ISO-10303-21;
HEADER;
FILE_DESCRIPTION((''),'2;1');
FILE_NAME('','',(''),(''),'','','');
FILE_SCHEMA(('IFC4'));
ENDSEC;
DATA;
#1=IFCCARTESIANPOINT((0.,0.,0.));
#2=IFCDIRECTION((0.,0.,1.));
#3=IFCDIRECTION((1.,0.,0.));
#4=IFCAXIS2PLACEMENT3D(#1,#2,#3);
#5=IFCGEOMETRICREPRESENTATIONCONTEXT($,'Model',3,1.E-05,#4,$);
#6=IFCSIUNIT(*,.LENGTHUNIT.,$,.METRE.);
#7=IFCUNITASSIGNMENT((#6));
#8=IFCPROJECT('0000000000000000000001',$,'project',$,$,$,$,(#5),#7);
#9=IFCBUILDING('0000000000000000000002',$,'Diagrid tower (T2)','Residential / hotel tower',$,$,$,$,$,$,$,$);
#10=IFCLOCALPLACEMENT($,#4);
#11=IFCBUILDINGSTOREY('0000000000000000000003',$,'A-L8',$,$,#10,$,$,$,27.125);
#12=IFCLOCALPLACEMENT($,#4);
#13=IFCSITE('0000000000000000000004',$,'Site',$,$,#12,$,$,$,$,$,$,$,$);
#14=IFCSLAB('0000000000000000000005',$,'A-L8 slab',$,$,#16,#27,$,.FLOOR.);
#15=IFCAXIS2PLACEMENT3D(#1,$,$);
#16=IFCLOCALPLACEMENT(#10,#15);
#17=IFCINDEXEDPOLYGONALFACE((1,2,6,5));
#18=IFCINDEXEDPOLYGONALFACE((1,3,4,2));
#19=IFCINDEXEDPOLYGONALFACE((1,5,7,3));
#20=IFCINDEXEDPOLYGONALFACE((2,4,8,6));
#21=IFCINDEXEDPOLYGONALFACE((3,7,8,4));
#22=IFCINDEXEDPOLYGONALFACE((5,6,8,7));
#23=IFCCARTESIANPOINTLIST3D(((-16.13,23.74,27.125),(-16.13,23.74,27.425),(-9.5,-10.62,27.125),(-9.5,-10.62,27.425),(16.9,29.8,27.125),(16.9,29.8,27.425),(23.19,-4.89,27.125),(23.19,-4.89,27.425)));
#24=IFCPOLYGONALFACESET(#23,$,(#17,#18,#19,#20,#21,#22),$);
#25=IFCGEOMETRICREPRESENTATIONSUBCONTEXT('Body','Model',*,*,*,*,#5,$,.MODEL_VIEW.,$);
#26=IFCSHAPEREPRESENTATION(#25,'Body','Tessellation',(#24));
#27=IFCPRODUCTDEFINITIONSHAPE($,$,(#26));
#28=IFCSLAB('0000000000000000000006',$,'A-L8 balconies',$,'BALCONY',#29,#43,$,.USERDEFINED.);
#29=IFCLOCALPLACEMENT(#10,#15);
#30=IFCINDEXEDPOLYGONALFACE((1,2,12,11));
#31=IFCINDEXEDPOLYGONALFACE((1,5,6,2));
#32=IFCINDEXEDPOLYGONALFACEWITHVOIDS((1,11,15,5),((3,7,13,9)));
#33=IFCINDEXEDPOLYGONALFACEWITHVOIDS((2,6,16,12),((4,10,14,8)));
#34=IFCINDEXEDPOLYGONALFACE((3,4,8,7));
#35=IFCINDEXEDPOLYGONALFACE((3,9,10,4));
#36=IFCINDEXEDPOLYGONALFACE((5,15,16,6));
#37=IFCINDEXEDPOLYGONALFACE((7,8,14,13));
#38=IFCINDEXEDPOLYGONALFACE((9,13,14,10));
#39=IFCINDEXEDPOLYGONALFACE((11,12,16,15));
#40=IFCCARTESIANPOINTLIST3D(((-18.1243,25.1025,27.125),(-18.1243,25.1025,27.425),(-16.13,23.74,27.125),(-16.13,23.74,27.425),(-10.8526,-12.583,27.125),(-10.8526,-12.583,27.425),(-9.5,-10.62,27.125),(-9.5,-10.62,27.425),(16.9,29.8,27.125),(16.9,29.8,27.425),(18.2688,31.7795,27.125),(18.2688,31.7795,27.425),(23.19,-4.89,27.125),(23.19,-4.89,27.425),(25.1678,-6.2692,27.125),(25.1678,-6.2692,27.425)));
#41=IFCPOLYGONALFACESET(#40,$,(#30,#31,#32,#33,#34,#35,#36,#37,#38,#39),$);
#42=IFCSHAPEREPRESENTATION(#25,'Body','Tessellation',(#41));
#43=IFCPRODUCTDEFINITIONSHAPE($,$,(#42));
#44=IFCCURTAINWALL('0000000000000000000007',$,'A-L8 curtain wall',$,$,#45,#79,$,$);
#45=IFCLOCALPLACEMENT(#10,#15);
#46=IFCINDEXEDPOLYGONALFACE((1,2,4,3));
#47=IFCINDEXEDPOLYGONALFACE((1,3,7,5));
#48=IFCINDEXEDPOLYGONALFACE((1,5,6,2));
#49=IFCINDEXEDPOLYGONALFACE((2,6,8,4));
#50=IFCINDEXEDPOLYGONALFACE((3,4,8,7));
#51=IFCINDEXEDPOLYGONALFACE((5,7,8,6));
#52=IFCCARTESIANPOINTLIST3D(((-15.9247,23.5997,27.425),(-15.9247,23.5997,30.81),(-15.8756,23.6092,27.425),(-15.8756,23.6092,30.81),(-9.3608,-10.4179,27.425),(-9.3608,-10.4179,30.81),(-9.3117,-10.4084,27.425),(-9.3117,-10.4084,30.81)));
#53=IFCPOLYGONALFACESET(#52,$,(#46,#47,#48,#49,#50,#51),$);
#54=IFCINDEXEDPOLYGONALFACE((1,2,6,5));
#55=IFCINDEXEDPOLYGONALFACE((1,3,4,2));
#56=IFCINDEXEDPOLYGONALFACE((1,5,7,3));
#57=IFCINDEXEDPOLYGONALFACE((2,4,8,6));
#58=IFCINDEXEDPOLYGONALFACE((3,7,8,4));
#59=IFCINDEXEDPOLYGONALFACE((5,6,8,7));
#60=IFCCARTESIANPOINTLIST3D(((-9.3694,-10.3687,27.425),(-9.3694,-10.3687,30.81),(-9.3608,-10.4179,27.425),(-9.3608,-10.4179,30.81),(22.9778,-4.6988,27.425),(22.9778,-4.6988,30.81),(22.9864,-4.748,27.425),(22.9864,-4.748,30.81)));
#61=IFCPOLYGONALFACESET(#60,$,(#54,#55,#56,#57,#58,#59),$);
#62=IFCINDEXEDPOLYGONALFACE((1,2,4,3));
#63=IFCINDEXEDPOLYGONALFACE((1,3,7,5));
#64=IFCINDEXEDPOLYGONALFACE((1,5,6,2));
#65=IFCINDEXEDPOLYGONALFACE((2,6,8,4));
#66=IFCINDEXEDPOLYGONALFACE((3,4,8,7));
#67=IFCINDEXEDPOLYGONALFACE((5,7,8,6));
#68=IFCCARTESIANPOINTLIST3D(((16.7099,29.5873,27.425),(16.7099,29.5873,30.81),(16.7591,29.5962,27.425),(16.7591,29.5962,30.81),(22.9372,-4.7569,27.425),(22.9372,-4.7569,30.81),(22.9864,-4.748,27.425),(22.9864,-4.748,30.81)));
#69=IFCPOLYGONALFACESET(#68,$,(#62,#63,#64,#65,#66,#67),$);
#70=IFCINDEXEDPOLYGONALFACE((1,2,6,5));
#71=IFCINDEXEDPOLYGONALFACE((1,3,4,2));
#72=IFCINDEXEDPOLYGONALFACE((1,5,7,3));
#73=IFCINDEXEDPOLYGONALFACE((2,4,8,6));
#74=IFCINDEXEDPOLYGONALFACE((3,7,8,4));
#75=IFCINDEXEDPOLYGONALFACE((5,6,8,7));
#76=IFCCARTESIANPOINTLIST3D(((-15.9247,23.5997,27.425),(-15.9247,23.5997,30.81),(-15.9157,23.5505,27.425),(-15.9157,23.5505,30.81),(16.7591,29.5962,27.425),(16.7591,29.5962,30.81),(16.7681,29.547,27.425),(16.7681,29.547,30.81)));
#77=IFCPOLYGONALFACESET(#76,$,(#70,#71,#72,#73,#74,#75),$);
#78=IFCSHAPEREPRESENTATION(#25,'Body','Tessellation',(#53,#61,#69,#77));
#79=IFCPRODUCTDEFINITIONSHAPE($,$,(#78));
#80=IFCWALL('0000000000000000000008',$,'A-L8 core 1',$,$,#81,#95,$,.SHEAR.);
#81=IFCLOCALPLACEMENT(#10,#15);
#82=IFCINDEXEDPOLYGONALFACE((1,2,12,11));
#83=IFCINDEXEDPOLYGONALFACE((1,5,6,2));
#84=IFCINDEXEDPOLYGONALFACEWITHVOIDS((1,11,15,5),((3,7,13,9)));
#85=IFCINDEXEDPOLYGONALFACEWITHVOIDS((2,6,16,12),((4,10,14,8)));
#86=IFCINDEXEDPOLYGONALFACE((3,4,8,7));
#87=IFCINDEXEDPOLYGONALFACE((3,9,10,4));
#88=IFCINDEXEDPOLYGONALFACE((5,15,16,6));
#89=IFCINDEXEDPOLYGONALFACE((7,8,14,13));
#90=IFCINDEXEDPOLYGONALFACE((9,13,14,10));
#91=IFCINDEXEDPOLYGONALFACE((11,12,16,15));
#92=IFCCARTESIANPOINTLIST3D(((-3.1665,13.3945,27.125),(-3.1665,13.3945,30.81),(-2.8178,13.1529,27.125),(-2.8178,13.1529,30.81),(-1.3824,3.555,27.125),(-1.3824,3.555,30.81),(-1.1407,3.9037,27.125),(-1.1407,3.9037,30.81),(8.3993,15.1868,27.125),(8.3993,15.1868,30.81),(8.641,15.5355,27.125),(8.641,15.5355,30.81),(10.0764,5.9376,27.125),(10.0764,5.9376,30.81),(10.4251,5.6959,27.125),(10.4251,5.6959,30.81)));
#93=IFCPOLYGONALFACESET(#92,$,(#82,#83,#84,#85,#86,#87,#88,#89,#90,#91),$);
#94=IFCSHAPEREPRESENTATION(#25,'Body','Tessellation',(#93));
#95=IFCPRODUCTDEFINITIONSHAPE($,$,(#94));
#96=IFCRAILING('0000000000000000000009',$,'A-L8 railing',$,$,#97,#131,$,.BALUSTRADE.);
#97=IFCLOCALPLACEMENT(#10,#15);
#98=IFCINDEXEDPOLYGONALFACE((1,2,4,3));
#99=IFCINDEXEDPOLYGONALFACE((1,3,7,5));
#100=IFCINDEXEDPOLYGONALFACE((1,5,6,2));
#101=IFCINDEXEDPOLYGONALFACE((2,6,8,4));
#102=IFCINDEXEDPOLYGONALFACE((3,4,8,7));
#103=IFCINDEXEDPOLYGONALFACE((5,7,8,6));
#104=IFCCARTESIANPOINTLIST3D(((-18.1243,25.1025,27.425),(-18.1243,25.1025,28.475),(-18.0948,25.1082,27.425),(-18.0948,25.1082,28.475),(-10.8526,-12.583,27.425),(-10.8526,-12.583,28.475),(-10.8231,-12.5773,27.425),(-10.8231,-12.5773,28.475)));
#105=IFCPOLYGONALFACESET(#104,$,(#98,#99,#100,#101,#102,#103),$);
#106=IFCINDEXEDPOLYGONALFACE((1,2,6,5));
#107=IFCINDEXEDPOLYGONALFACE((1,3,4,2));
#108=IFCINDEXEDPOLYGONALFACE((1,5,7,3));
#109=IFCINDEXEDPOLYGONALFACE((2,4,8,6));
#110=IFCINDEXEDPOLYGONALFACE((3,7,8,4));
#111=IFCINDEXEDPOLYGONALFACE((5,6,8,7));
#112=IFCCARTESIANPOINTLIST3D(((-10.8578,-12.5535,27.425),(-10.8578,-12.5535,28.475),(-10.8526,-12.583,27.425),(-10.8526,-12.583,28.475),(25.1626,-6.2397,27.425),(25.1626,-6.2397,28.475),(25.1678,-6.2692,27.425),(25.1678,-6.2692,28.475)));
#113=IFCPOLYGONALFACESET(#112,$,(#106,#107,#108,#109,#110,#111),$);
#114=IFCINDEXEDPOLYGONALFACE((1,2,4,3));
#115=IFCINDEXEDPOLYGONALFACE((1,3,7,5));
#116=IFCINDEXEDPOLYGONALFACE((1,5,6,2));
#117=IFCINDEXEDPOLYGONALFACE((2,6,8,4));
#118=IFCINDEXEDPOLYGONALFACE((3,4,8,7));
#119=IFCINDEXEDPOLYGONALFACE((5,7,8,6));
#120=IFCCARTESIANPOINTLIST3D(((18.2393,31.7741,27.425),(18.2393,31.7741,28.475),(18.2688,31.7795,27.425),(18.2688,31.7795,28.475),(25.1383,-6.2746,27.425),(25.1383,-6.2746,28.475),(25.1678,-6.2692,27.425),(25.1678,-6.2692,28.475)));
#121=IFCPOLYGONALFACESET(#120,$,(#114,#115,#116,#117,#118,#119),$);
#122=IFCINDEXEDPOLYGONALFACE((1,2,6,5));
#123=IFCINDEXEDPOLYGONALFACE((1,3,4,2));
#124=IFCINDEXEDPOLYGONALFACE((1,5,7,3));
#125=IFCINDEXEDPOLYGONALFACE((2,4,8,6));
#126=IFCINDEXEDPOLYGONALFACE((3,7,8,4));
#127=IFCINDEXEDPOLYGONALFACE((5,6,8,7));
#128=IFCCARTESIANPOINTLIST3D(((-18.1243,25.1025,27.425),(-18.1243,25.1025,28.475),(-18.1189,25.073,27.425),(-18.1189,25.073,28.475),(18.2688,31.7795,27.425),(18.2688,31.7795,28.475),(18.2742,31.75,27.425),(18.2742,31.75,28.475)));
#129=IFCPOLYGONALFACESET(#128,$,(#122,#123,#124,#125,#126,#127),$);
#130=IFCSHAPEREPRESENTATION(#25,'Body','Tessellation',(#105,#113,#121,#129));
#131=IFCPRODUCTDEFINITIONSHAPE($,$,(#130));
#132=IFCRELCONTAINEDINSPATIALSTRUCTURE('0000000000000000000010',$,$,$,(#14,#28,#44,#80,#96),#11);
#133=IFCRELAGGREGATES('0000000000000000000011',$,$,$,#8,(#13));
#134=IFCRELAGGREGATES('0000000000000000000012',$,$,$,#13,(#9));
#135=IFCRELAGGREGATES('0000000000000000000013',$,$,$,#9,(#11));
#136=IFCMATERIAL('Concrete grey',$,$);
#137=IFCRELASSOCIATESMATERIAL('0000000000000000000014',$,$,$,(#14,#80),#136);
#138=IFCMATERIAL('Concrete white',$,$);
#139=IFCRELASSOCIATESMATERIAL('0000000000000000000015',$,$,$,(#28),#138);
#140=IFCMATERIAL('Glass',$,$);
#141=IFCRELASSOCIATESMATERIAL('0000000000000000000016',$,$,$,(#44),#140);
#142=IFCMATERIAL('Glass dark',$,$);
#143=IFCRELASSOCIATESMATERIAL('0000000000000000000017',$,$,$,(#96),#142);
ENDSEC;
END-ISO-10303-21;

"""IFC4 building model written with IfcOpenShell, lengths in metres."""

from ifc_helpers import new_model, si_unit, frame, origin_with_axes, place, context, subcontext, project, spatial, polyline, outline, extrude, material, element, save


model = new_model("IFC4")

# Units and contexts
model_context = context("Model", 3, precision=1e-05, world=origin_with_axes())
body_context = subcontext(model_context, "Body", "Model", "MODEL_VIEW")
ifc_project = project(units=[si_unit("LENGTHUNIT", "METRE")], contexts=[model_context])

# Site, building, storey
site_placement = place(None, origin_with_axes())
site = spatial("IfcSite", under=ifc_project, at=site_placement, Name="Site")
building = spatial("IfcBuilding", under=site, Name="Diagrid tower (T2)", Description="Residential / hotel tower")
storey_placement = place(None, origin_with_axes())
storey = spatial("IfcBuildingStorey", under=building, at=storey_placement, Name="A-L8", Elevation=27.125)

# Slabs
ifc_material_1 = material(Name="Concrete grey")
slab_1_placement = place(storey_placement, origin_with_axes())
element("IfcSlab", 1, at=slab_1_placement, inside=storey, material=ifc_material_1, Name="A-L8 slab", PredefinedType="FLOOR", context=body_context, shape_type="SweptSolid", body=[
    extrude(outline(polyline([(-16.13, 23.74), (-9.5, -10.62), (23.19, -4.89), (16.9, 29.8), (-16.13, 23.74)])), frame((0.0, 0.0, 27.125), z_axis=(0.0, 0.0, 1.0), x_axis=(1.0, 0.0, 0.0)), (0.0, 0.0, 1.0), 0.3),
])
ifc_material_2 = material(Name="Concrete white")
slab_2_placement = place(storey_placement, origin_with_axes())
element("IfcSlab", 2, at=slab_2_placement, inside=storey, material=ifc_material_2, Name="A-L8 balconies", ObjectType="BALCONY", PredefinedType="USERDEFINED", context=body_context, shape_type="SweptSolid", body=[
    extrude(outline(polyline([(-18.1243, 25.1025), (-10.8526, -12.583), (25.1678, -6.2692), (18.2688, 31.7795), (-18.1243, 25.1025)]), holes=[polyline([(-16.13, 23.74), (-9.5, -10.62), (23.19, -4.89), (16.9, 29.8), (-16.13, 23.74)])]), frame((0.0, 0.0, 27.125), z_axis=(0.0, 0.0, 1.0), x_axis=(1.0, 0.0, 0.0)), (0.0, 0.0, 1.0), 0.3),
])

# Curtain wall
ifc_material_3 = material(Name="Glass")
curtain_wall_placement = place(storey_placement, origin_with_axes())
element("IfcCurtainWall", 3, at=curtain_wall_placement, inside=storey, material=ifc_material_3, Name="A-L8 curtain wall", context=body_context, shape_type="SweptSolid", body=[
    extrude(outline(polyline([(-15.9247, 23.5997), (-9.3608, -10.4179), (-9.3117, -10.4084), (-15.8756, 23.6092), (-15.9247, 23.5997)])), frame((0.0, 0.0, 27.425), z_axis=(0.0, 0.0, 1.0), x_axis=(1.0, 0.0, 0.0)), (0.0, 0.0, 1.0), 3.385),
    extrude(outline(polyline([(-9.3608, -10.4179), (22.9864, -4.748), (22.9778, -4.6988), (-9.3694, -10.3687), (-9.3608, -10.4179)])), frame((0.0, 0.0, 27.425), z_axis=(0.0, 0.0, 1.0), x_axis=(1.0, 0.0, 0.0)), (0.0, 0.0, 1.0), 3.385),
    extrude(outline(polyline([(22.9864, -4.748), (16.7591, 29.5962), (16.7099, 29.5873), (22.9372, -4.7569), (22.9864, -4.748)])), frame((0.0, 0.0, 27.425), z_axis=(0.0, 0.0, 1.0), x_axis=(1.0, 0.0, 0.0)), (0.0, 0.0, 1.0), 3.385),
    extrude(outline(polyline([(16.7591, 29.5962), (-15.9247, 23.5997), (-15.9157, 23.5505), (16.7681, 29.547), (16.7591, 29.5962)])), frame((0.0, 0.0, 27.425), z_axis=(0.0, 0.0, 1.0), x_axis=(1.0, 0.0, 0.0)), (0.0, 0.0, 1.0), 3.385),
])

# Wall
wall_placement = place(storey_placement, origin_with_axes())
element("IfcWall", 4, at=wall_placement, inside=storey, material=ifc_material_1, Name="A-L8 core 1", PredefinedType="SHEAR", context=body_context, shape_type="SweptSolid", body=[
    extrude(outline(polyline([(10.4251, 5.6959), (8.641, 15.5355), (-3.1665, 13.3945), (-1.3824, 3.555), (10.4251, 5.6959)]), holes=[polyline([(10.0764, 5.9376), (8.3993, 15.1868), (-2.8178, 13.1529), (-1.1407, 3.9037), (10.0764, 5.9376)])]), frame((0.0, 0.0, 27.125), z_axis=(0.0, 0.0, 1.0), x_axis=(1.0, 0.0, 0.0)), (0.0, 0.0, 1.0), 3.685),
])

# Railing
ifc_material_4 = material(Name="Glass dark")
railing_placement = place(storey_placement, origin_with_axes())
element("IfcRailing", 5, at=railing_placement, inside=storey, material=ifc_material_4, Name="A-L8 railing", PredefinedType="BALUSTRADE", context=body_context, shape_type="SweptSolid", body=[
    extrude(outline(polyline([(-18.1243, 25.1025), (-10.8526, -12.583), (-10.8231, -12.5773), (-18.0948, 25.1082), (-18.1243, 25.1025)])), frame((0.0, 0.0, 27.425), z_axis=(0.0, 0.0, 1.0), x_axis=(1.0, 0.0, 0.0)), (0.0, 0.0, 1.0), 1.05),
    extrude(outline(polyline([(-10.8526, -12.583), (25.1678, -6.2692), (25.1626, -6.2397), (-10.8578, -12.5535), (-10.8526, -12.583)])), frame((0.0, 0.0, 27.425), z_axis=(0.0, 0.0, 1.0), x_axis=(1.0, 0.0, 0.0)), (0.0, 0.0, 1.0), 1.05),
    extrude(outline(polyline([(25.1678, -6.2692), (18.2688, 31.7795), (18.2393, 31.7741), (25.1383, -6.2746), (25.1678, -6.2692)])), frame((0.0, 0.0, 27.425), z_axis=(0.0, 0.0, 1.0), x_axis=(1.0, 0.0, 0.0)), (0.0, 0.0, 1.0), 1.05),
    extrude(outline(polyline([(18.2688, 31.7795), (-18.1243, 25.1025), (-18.1189, 25.073), (18.2742, 31.75), (18.2688, 31.7795)])), frame((0.0, 0.0, 27.425), z_axis=(0.0, 0.0, 1.0), x_axis=(1.0, 0.0, 0.0)), (0.0, 0.0, 1.0), 1.05),
])

save(model, "model.ifc")
